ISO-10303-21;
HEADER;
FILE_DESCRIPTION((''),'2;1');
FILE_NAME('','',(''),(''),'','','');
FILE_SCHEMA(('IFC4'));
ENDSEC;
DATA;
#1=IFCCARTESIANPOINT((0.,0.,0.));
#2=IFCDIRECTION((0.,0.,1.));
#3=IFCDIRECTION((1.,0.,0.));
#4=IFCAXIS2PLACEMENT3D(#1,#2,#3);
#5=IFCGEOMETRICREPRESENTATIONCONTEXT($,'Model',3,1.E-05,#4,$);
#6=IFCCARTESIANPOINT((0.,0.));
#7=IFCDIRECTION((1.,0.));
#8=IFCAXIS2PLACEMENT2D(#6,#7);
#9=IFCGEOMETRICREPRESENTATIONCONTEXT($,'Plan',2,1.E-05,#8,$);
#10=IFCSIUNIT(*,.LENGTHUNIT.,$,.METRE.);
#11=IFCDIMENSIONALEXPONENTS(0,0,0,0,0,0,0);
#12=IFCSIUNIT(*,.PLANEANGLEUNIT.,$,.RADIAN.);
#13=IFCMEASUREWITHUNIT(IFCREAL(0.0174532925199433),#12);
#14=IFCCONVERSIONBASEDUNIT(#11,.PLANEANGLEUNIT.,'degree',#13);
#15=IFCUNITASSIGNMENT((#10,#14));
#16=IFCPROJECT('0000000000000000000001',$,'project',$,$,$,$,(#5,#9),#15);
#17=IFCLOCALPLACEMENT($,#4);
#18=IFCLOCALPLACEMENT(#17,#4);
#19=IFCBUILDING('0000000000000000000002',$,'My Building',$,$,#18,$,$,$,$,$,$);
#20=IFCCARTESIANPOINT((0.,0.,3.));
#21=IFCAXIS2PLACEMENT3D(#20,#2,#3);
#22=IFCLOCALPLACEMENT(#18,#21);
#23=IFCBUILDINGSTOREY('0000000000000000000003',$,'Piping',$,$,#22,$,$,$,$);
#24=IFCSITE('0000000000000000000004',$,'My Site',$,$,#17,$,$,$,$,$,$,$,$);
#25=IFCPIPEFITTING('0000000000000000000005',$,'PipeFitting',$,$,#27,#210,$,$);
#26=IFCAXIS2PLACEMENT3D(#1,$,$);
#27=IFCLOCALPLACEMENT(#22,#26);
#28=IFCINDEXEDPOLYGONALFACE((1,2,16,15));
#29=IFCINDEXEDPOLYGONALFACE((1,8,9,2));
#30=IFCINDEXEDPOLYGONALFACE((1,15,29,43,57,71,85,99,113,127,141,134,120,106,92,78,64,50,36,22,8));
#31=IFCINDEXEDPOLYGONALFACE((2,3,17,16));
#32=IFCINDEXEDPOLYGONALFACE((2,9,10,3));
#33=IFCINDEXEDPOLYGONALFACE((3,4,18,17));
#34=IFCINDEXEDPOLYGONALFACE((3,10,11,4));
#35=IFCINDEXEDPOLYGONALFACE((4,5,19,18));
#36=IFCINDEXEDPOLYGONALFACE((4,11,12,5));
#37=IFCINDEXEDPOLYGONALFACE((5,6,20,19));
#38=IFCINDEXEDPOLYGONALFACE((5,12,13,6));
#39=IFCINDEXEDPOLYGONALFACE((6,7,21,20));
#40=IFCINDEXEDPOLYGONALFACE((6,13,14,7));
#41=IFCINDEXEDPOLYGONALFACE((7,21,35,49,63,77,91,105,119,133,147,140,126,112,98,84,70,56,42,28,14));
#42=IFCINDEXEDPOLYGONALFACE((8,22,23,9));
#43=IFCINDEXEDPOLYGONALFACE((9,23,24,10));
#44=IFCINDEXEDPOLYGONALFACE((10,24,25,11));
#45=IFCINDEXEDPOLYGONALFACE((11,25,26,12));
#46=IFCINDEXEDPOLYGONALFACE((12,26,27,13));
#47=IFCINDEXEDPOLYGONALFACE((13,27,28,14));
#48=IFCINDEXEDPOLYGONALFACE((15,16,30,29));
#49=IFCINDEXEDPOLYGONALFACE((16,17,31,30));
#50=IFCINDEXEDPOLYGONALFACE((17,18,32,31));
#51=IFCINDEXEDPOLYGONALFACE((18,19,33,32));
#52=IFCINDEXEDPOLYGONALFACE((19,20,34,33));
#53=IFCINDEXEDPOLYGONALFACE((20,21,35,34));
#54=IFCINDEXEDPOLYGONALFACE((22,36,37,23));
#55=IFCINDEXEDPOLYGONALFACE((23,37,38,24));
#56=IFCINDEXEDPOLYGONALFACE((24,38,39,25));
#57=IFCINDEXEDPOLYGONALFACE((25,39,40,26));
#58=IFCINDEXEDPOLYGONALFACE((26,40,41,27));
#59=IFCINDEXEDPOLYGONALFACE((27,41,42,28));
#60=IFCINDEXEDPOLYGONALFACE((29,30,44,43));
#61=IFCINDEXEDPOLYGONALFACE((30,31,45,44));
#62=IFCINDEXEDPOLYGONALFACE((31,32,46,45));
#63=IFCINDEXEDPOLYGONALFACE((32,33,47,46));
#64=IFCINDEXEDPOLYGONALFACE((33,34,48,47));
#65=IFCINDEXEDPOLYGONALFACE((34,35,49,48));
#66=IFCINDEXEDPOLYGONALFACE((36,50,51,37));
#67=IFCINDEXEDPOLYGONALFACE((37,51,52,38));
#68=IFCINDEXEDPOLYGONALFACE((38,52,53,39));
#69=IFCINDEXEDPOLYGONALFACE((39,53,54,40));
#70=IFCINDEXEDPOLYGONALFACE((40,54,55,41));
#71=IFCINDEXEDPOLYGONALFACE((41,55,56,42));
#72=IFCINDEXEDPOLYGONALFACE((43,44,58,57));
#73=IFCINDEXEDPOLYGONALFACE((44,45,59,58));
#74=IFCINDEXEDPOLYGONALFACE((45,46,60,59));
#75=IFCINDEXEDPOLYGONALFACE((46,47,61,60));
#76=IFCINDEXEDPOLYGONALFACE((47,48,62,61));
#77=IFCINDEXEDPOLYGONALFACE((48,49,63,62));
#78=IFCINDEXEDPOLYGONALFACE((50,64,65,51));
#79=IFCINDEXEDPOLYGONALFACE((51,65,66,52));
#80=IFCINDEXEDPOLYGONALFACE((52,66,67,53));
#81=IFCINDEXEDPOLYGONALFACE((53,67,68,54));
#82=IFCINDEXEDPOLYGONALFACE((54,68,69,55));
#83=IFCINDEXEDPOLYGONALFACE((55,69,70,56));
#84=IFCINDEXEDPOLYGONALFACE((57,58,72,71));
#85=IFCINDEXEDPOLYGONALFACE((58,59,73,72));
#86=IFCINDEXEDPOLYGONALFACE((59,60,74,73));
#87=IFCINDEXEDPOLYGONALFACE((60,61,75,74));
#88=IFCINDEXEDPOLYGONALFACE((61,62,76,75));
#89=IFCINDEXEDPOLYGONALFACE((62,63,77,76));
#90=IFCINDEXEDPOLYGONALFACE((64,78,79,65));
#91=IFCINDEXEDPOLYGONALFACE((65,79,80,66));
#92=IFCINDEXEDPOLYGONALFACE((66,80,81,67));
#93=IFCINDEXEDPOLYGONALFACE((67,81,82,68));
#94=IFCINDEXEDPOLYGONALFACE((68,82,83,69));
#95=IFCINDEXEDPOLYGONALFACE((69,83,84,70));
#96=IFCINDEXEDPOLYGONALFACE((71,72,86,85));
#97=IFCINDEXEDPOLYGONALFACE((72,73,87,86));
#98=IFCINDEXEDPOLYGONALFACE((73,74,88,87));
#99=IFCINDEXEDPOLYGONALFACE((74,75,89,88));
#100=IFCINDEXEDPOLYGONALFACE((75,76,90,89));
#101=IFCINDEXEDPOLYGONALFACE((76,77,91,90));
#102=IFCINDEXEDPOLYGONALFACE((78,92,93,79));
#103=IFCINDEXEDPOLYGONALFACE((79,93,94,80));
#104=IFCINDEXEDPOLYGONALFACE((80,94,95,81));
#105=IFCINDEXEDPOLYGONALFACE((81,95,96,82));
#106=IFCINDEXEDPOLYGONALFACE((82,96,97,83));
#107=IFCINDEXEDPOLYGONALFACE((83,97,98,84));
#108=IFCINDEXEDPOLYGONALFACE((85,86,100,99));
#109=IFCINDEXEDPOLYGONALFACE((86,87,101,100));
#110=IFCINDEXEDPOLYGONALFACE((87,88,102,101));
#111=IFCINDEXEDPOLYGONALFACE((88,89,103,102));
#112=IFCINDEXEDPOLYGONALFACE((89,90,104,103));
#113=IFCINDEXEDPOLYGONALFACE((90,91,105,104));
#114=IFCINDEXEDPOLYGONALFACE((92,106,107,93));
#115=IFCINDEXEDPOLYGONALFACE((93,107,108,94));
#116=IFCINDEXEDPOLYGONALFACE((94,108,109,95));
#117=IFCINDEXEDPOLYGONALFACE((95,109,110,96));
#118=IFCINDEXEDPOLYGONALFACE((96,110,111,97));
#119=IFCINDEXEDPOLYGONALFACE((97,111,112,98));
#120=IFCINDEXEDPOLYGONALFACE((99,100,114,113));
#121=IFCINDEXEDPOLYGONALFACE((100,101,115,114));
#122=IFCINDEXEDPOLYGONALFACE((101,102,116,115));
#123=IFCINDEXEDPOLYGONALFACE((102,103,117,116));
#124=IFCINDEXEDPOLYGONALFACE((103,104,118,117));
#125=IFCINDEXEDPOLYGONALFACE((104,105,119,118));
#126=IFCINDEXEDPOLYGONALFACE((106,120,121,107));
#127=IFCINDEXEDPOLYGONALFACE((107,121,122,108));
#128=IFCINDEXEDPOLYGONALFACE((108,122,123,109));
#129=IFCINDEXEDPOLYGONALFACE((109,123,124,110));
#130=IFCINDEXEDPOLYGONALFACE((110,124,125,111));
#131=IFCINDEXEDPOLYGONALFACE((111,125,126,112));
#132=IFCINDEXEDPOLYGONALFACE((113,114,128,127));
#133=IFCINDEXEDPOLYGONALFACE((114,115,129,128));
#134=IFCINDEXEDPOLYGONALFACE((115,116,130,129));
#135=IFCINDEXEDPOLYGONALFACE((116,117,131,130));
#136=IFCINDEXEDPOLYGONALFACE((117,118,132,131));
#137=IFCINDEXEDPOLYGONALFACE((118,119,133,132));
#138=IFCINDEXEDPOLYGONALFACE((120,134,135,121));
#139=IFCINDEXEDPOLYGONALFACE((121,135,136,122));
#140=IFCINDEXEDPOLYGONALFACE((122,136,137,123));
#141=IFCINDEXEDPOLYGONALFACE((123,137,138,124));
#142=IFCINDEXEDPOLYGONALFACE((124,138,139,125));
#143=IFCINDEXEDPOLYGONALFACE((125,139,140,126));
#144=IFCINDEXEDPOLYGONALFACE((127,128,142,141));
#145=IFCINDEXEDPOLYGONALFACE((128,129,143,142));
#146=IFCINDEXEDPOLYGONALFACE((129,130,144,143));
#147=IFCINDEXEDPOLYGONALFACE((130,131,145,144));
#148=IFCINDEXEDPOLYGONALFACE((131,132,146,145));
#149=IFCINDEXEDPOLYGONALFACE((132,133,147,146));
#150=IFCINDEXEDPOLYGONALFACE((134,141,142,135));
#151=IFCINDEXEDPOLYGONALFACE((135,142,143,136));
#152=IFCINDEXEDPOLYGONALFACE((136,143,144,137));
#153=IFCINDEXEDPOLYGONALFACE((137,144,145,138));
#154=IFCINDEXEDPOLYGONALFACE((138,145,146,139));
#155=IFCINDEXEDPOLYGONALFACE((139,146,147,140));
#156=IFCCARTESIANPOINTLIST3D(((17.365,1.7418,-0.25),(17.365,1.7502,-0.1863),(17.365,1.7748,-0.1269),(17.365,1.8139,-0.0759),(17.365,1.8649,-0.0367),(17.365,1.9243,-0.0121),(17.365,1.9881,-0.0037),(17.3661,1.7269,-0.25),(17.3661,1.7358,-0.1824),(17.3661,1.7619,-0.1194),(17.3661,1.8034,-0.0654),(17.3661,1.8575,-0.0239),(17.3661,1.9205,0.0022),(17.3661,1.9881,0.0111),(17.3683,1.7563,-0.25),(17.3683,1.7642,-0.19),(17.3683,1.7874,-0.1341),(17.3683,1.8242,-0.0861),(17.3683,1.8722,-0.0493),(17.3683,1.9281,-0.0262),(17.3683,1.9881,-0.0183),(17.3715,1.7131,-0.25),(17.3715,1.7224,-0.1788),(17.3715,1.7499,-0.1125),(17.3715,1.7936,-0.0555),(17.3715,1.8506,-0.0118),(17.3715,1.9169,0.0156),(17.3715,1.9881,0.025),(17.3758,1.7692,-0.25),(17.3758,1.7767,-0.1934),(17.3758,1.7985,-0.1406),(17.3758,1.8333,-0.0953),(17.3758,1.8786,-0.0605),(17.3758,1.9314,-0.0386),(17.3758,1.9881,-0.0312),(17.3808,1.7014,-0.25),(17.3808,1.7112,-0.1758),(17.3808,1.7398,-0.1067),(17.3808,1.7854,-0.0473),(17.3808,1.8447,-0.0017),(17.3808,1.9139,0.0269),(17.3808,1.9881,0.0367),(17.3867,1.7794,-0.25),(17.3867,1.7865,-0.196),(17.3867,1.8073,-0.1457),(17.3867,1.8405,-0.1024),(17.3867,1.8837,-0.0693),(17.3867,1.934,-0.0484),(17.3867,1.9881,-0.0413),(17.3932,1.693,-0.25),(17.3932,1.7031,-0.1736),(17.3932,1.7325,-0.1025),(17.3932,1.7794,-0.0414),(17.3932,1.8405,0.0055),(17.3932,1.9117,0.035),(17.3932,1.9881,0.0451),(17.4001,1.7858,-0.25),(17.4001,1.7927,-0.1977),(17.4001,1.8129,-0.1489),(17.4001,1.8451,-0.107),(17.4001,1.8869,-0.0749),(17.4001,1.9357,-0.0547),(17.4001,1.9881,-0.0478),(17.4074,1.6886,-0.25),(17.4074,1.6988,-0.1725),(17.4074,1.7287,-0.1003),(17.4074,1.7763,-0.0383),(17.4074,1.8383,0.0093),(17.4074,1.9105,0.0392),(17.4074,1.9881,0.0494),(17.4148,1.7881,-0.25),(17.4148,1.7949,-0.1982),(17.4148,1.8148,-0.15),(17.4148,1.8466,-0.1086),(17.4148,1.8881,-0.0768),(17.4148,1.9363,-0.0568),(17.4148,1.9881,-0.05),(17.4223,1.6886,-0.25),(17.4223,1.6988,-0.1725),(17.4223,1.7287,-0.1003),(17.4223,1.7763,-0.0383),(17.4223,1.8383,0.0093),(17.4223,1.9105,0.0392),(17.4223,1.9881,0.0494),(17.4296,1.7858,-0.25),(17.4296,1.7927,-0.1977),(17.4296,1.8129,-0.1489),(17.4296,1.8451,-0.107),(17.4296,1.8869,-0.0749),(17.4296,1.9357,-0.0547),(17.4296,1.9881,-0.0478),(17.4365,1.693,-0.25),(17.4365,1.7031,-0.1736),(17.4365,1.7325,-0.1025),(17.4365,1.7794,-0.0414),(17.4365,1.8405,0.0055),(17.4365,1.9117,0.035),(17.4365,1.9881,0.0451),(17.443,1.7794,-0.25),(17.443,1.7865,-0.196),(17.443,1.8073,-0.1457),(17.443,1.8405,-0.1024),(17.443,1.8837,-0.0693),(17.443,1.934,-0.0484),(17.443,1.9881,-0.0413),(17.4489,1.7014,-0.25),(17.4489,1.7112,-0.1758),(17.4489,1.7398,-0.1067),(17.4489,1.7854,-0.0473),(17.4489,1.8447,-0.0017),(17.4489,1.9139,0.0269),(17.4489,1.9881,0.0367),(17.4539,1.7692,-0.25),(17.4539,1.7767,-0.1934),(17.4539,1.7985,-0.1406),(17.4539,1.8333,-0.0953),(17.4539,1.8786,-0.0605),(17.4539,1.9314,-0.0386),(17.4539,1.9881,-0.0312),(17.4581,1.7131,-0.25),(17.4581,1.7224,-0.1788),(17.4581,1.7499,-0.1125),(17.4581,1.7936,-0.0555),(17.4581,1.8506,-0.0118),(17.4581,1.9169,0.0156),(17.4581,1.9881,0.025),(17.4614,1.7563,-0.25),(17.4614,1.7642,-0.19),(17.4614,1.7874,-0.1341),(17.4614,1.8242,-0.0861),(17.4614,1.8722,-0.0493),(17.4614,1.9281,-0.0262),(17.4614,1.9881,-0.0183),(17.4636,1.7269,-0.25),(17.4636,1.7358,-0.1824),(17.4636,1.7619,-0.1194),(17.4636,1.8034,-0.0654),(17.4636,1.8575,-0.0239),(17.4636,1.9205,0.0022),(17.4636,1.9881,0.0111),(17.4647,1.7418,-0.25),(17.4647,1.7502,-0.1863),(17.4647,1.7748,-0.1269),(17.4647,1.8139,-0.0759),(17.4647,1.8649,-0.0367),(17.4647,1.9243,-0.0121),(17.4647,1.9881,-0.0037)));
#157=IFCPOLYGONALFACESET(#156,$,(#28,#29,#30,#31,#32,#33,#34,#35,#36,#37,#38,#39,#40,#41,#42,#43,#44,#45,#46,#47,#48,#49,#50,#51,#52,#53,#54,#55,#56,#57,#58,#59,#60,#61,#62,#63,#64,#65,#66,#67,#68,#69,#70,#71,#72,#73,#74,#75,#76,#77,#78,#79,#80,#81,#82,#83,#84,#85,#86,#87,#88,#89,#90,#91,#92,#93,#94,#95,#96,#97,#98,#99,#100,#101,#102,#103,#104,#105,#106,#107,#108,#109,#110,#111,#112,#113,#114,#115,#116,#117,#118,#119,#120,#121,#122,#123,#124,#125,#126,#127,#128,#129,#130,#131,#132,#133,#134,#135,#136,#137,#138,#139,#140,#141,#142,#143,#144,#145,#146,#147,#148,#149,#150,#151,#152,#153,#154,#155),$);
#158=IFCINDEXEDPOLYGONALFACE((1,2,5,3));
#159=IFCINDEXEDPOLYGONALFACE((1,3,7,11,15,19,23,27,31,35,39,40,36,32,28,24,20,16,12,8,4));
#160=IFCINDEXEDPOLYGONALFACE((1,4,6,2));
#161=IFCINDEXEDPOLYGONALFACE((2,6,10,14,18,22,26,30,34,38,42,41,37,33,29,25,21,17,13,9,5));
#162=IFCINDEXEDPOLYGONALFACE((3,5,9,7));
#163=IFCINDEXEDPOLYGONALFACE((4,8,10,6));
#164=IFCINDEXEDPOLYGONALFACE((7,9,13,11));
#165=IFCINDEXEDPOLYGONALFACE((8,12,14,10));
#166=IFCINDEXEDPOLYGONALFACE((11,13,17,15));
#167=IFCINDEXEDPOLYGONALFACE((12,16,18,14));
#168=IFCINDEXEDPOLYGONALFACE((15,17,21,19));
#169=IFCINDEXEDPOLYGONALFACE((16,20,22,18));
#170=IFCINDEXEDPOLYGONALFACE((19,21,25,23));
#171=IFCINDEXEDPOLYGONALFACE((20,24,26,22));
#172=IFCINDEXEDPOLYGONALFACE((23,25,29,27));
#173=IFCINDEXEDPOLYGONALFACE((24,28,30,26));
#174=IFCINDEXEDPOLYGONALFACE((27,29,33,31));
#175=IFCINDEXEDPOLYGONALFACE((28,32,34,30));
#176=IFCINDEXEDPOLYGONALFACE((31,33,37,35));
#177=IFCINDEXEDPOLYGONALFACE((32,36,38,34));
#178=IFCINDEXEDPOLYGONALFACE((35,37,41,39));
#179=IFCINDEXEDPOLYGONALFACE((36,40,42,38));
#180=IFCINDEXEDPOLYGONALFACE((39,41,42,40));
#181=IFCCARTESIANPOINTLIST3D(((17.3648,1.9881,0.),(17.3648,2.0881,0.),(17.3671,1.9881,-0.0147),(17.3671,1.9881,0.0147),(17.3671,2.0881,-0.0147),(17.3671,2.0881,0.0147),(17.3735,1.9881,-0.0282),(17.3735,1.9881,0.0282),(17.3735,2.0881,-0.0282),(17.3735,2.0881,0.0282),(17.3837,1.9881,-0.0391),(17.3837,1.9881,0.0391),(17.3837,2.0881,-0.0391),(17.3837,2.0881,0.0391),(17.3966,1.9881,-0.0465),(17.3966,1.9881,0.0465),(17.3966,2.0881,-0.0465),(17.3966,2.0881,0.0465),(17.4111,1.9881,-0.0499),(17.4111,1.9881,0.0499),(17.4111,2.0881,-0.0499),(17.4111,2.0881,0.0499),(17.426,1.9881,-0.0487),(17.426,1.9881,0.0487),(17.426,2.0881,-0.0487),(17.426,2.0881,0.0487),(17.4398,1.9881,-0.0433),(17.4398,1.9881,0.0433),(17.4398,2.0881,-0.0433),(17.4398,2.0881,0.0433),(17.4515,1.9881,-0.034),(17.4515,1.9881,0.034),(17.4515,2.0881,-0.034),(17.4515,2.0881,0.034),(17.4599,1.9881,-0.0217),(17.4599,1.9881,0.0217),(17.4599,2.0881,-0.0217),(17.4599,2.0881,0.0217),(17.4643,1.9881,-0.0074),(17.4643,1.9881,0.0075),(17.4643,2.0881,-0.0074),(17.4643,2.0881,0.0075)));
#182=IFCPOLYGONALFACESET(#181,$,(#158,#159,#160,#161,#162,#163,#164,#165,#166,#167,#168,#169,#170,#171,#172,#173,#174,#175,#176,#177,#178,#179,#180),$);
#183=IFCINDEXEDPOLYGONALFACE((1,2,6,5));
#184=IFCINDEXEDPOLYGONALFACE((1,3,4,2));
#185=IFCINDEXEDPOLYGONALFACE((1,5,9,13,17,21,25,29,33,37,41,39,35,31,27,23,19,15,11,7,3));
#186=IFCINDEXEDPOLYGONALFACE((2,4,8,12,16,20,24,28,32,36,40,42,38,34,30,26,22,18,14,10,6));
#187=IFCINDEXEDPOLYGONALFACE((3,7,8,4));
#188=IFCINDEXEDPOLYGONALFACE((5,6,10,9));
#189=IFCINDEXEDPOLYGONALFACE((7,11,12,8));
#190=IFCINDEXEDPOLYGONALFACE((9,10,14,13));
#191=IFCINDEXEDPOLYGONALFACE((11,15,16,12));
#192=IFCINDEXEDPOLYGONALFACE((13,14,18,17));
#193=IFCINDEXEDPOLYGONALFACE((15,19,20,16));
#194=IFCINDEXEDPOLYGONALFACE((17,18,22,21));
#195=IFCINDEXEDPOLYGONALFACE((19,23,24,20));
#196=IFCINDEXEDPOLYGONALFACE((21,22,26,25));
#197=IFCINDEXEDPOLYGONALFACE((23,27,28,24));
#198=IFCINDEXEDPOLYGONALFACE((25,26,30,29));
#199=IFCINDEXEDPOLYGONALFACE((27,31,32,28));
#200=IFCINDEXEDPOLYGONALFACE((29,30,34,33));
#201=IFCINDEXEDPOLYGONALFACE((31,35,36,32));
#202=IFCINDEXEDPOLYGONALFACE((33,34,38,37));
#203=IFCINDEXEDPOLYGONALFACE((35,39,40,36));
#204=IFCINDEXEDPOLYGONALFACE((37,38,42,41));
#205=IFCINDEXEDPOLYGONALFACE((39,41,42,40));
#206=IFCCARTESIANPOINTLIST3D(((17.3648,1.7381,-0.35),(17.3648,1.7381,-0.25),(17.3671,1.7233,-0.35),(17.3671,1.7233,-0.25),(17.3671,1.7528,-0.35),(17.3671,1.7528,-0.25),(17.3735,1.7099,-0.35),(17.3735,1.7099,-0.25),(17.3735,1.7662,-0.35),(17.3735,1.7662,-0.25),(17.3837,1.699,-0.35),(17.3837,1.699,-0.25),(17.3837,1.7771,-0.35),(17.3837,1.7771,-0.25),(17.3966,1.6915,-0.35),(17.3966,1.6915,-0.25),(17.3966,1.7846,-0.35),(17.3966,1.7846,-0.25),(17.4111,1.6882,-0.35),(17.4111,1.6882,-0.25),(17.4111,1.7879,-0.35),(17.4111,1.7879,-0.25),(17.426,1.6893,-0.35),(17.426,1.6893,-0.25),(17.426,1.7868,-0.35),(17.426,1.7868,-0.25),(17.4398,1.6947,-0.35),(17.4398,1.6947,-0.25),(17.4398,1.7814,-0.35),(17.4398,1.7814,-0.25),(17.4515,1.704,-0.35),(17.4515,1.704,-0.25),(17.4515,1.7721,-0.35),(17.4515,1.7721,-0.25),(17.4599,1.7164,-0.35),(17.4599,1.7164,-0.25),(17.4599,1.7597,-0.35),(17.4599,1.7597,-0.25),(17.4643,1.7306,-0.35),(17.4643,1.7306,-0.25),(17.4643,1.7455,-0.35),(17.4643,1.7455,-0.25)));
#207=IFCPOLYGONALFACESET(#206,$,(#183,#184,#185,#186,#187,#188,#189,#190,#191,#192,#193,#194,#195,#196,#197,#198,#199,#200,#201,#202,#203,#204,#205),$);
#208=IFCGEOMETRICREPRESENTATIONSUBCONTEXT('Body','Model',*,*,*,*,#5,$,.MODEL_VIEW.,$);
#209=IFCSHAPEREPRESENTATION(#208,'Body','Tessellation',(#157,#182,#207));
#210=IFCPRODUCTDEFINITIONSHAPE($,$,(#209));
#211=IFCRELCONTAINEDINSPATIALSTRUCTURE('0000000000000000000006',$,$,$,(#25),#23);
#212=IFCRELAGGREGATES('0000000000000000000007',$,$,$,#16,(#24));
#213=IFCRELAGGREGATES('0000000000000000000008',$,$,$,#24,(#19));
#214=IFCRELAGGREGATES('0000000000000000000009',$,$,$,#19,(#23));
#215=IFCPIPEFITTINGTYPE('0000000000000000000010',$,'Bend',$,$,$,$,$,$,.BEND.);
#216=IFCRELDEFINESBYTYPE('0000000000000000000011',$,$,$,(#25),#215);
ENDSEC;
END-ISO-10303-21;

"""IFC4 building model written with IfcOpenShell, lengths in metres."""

from ifc_helpers import new_model, entity, si_unit, converted_unit, frame, origin_with_axes, origin_2d_with_axis, place, context, subcontext, project, spatial, circle, extrude, source, transform, mapped, type_object, type_shapes, element, save


model = new_model("IFC4")

# Units and contexts
model_context = context("Model", 3, precision=1e-05, world=origin_with_axes())
plan_context = context("Plan", 2, precision=1e-05, world=origin_2d_with_axis())
body_context = subcontext(model_context, "Body", "Model", "MODEL_VIEW")
ifc_project = project(units=[si_unit("LENGTHUNIT", "METRE"), converted_unit("PLANEANGLEUNIT", "degree", entity("IfcReal", 0.0174532925199433), si_unit("PLANEANGLEUNIT", "RADIAN"), dimensions=[0, 0, 0, 0, 0, 0, 0])], contexts=[model_context, plan_context])

# Site, building, storey
site_placement = place(None, origin_with_axes())
site = spatial("IfcSite", under=ifc_project, at=site_placement, Name="My Site")
building_placement = place(site_placement, origin_with_axes())
building = spatial("IfcBuilding", under=site, at=building_placement, Name="My Building")
storey_placement = place(building_placement, frame((0.0, 0.0, 3.0), z_axis=(0.0, 0.0, 1.0), x_axis=(1.0, 0.0, 0.0)))
storey = spatial("IfcBuildingStorey", under=building, at=storey_placement, Name="Piping")

# Pipe fitting
pipe_fitting_type = type_object("IfcPipeFittingType", Name="Bend", PredefinedType="BEND")
shared_shape = source(origin_with_axes(), body_context, "Body", "SolidModel", [
    entity("IfcSweptDiskSolid", entity("IfcIndexedPolyCurve", entity("IfcCartesianPointList3D", [[0.0, 0.0, -0.1], [0.0, -0.0732, -0.2768], [0.0, -0.25, -0.35]]), [entity("IfcArcIndex", [1, 2, 3])]), 0.05),
    extrude(circle(Radius=0.05), origin_with_axes(), (0.0, 0.0, -1.0), 0.1),
    extrude(circle(Radius=0.05), frame((0.0, -0.25, -0.35), z_axis=(0.0, -1.0, 0.0), x_axis=(1.0, 0.0, 0.0)), (0.0, 0.0, 1.0), 0.1),
])
type_shapes(pipe_fitting_type, [shared_shape])
for number, where, z_axis, x_axis, name in (
    (1, (17.4148, 2.0881, 0.0), (0.0, 1.0, 0.0), (-1.0, 0.0, 0.0), "PipeFitting"),
):
    element("IfcPipeFitting", number, at=place(storey_placement, frame(where, z_axis=z_axis, x_axis=x_axis)), inside=storey, type_object=pipe_fitting_type, Name=name, context=body_context, shape_type="MappedRepresentation", body=[
        mapped(shared_shape, transform((0.0, 0.0, 0.0), x_axis=(1.0, 0.0, 0.0), y_axis=(0.0, 1.0, 0.0), z_axis=(0.0, 0.0, 1.0), scale=1.0)),
    ])

save(model, "model.ifc")
